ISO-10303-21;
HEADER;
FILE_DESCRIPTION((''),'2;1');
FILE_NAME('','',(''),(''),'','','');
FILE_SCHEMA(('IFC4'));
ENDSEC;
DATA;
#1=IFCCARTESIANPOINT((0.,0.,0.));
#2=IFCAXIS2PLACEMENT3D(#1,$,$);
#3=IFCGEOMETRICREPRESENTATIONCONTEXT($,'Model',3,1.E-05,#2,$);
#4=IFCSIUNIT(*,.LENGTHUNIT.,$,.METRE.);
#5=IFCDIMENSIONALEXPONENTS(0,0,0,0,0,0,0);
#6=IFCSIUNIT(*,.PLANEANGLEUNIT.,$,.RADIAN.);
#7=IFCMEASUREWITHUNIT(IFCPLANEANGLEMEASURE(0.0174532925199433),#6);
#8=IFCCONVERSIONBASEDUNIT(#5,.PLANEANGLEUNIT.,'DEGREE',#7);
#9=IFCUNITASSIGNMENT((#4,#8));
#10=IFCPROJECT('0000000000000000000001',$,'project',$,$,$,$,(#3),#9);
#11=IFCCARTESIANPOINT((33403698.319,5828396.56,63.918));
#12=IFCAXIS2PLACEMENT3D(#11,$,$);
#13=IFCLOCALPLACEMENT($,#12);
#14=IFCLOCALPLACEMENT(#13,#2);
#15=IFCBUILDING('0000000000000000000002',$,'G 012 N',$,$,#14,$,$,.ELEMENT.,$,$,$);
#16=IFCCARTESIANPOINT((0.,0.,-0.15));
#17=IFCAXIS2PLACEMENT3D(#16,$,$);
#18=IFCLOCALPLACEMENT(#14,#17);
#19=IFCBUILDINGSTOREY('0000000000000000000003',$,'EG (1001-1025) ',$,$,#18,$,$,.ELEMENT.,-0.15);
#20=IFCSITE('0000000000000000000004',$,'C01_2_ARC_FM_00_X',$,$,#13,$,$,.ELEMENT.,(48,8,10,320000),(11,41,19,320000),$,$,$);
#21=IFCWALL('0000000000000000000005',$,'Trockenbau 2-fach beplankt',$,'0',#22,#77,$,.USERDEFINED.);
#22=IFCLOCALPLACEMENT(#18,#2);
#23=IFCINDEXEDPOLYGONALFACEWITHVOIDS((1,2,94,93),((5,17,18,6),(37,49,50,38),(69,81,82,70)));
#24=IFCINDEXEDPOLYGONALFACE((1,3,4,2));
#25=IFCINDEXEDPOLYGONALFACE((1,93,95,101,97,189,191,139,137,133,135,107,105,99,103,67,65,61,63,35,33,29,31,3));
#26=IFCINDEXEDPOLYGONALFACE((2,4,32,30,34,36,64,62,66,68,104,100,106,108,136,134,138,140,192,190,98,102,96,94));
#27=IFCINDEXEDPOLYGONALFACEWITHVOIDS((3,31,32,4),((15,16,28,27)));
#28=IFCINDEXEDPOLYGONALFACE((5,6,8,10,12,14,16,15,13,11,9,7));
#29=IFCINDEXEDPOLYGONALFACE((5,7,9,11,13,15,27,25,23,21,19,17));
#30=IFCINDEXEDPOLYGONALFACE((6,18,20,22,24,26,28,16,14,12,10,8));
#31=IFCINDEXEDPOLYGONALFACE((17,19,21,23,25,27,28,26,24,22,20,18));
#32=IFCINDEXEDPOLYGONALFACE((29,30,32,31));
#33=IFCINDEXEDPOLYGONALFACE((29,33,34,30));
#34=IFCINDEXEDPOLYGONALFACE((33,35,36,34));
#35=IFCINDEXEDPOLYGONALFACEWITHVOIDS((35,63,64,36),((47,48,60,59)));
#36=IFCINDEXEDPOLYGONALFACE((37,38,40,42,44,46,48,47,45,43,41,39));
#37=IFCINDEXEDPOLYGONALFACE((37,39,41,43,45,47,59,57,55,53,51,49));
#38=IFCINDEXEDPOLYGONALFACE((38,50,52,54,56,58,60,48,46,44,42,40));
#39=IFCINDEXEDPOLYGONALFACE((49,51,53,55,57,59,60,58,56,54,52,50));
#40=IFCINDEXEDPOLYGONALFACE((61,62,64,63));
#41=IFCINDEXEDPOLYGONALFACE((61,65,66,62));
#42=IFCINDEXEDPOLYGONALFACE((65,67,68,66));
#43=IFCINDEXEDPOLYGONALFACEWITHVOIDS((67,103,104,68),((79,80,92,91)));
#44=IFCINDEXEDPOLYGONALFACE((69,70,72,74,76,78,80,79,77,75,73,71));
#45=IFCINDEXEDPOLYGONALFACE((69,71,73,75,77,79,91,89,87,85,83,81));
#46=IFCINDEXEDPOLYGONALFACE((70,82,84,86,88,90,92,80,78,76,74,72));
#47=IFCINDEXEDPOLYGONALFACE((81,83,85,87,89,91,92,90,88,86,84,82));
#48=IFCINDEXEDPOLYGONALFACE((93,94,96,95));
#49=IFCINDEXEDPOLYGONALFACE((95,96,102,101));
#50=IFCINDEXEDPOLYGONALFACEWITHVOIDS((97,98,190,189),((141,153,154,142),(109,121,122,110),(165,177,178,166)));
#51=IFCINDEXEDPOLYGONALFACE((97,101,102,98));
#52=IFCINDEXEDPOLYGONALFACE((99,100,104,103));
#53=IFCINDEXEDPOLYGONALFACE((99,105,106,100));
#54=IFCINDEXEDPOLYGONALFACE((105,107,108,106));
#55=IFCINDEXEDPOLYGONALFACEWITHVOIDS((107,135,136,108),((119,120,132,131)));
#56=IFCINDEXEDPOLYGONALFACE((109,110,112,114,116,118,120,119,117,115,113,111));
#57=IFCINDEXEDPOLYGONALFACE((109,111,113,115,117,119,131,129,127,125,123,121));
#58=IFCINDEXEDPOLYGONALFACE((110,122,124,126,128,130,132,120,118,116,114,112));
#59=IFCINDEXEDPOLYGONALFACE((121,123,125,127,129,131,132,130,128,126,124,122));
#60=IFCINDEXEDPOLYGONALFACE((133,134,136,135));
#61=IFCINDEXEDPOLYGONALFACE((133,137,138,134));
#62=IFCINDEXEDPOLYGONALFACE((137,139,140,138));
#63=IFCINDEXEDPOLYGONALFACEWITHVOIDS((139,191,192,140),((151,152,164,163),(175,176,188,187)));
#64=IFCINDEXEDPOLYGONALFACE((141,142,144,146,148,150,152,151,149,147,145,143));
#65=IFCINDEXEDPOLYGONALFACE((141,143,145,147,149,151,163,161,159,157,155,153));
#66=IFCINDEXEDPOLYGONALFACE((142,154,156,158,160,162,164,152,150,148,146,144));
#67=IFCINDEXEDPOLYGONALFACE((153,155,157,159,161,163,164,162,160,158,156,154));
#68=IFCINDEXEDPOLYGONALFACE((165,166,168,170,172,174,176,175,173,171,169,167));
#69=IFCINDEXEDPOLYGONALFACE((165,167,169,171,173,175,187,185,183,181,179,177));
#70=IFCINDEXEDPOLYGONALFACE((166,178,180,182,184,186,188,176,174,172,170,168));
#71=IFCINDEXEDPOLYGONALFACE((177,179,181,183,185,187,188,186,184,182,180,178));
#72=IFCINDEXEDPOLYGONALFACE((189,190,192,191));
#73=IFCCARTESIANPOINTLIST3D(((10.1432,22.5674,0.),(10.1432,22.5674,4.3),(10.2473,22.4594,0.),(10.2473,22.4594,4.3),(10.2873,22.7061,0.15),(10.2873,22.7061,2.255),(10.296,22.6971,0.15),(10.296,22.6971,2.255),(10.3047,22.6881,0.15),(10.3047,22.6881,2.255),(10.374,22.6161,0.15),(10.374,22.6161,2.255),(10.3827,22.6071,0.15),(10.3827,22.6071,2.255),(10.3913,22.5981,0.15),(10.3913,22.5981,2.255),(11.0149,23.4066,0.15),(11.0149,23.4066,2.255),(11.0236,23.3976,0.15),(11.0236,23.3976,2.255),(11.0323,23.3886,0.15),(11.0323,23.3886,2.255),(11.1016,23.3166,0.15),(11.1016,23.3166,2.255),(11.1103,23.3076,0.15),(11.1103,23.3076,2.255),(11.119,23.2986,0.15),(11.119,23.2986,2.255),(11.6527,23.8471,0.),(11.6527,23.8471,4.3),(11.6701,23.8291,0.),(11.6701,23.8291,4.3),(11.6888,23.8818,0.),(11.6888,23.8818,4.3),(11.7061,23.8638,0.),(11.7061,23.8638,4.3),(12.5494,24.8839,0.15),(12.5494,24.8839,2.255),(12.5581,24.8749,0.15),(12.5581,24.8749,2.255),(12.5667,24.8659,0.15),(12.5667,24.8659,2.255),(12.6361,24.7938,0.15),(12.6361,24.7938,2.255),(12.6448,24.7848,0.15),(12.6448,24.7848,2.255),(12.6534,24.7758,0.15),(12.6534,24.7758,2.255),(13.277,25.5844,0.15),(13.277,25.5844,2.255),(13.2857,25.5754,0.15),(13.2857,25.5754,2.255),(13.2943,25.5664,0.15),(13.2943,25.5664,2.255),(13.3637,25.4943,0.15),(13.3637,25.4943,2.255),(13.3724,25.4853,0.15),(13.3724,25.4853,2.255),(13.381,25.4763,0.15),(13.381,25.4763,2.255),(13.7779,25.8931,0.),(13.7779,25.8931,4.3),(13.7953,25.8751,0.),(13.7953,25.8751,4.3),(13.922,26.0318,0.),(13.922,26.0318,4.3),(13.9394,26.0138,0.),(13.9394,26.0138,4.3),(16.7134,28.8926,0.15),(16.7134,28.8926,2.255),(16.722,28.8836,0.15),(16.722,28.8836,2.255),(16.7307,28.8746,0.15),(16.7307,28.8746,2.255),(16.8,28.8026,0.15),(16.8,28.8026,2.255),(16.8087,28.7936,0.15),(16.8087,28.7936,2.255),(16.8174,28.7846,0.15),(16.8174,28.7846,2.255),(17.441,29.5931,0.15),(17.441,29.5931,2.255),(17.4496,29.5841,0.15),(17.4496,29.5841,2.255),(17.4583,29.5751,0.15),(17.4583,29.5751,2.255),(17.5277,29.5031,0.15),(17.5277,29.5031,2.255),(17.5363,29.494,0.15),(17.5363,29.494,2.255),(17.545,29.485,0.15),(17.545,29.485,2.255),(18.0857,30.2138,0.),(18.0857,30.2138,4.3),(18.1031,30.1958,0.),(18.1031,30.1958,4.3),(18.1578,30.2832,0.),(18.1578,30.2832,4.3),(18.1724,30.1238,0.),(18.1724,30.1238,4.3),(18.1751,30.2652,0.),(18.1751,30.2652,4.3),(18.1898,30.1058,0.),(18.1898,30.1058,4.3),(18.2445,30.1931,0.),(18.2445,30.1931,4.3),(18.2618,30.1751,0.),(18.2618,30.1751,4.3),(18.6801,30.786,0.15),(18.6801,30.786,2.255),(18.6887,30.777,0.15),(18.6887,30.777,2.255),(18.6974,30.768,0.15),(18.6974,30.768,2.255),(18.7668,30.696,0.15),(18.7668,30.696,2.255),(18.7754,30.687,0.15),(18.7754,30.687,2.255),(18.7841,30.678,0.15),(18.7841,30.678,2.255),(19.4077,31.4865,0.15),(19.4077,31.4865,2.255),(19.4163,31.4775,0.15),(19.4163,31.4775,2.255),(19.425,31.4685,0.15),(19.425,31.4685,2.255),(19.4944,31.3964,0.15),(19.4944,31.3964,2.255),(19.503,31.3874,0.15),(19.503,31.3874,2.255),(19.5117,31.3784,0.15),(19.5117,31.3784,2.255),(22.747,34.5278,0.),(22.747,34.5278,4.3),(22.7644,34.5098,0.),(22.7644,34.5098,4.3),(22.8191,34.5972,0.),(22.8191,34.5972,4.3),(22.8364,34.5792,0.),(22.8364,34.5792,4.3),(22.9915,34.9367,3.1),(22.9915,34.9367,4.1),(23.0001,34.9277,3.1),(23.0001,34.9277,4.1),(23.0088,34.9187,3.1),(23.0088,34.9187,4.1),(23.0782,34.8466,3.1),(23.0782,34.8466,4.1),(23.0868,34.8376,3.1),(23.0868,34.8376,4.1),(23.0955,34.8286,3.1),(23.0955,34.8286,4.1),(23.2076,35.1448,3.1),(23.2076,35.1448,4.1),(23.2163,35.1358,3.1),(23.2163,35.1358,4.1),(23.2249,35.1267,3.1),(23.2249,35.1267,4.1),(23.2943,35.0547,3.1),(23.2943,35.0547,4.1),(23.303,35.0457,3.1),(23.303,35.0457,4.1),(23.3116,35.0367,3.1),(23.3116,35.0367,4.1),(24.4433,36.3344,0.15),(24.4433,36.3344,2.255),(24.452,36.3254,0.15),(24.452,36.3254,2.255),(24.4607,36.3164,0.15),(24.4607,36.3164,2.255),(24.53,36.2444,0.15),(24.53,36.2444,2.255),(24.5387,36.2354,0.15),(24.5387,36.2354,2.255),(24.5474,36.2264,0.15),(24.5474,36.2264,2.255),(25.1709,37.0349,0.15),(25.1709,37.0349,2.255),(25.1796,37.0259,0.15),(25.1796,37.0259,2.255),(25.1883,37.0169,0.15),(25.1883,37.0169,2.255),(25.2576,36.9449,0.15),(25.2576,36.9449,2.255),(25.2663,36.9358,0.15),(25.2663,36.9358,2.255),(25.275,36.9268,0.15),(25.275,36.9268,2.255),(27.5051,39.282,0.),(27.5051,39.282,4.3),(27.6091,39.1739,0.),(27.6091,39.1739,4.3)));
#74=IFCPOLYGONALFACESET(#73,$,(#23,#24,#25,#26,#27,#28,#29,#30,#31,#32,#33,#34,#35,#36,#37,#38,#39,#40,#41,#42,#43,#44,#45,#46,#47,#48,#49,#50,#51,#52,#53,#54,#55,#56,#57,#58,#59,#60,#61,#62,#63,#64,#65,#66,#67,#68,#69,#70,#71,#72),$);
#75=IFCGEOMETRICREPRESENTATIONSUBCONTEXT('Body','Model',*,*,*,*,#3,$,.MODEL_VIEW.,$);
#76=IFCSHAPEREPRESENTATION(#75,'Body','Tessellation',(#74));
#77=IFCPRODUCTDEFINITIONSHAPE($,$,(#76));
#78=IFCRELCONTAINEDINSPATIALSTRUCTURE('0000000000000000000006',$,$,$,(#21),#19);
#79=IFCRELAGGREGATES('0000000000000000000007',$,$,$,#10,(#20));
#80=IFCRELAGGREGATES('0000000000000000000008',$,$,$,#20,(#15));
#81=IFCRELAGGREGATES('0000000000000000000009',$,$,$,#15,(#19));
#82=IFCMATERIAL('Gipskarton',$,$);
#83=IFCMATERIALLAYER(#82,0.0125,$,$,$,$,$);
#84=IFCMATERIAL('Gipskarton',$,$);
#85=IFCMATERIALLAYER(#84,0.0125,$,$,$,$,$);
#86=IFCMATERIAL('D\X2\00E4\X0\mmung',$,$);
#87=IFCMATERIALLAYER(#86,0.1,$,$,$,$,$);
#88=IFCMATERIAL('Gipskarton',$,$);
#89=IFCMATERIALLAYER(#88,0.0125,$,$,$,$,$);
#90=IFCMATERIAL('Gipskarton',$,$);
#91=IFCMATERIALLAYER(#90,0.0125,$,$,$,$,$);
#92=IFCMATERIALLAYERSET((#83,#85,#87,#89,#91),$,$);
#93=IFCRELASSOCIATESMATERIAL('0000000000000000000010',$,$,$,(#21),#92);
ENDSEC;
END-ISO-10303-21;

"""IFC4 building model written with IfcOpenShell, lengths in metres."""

from ifc_helpers import new_model, entity, si_unit, converted_unit, frame, origin, origin_with_axes, place, context, subcontext, project, spatial, polyline, outline, extrude, material, layer, layer_set, layer_usage, element, save


model = new_model("IFC4")

# Units and contexts
model_context = context("Model", 3, precision=1e-05, world=origin())
body_context = subcontext(model_context, "Body", "Model", "MODEL_VIEW")
ifc_project = project(units=[si_unit("LENGTHUNIT", "METRE"), converted_unit("PLANEANGLEUNIT", "DEGREE", entity("IfcPlaneAngleMeasure", 0.0174532925199433), si_unit("PLANEANGLEUNIT", "RADIAN"), dimensions=[0, 0, 0, 0, 0, 0, 0])], contexts=[model_context])

# Site, building, storey
site_placement = place(None, frame((33403698.319, 5828396.56, 63.918)))
site = spatial("IfcSite", under=ifc_project, at=site_placement, Name="C01_2_ARC_FM_00_X", CompositionType="ELEMENT", RefLatitude=(48, 8, 10, 320000), RefLongitude=(11, 41, 19, 320000))
building_placement = place(site_placement, origin())
building = spatial("IfcBuilding", under=site, at=building_placement, Name="G 012 N", CompositionType="ELEMENT")
storey_placement = place(building_placement, frame((0.0, 0.0, -0.15)))
storey = spatial("IfcBuildingStorey", under=building, at=storey_placement, Name="EG (1001-1025) ", CompositionType="ELEMENT", Elevation=-0.15)

# Wall, openings
ifc_material_1 = material(Name="Gipskarton")
ifc_layer_1 = layer(ifc_material_1, 0.0125)
ifc_material_2 = material(Name="Gipskarton")
ifc_layer_2 = layer(ifc_material_2, 0.0125)
ifc_material_3 = material(Name="Dämmung")
ifc_layer_3 = layer(ifc_material_3, 0.1)
ifc_material_4 = material(Name="Gipskarton")
ifc_layer_4 = layer(ifc_material_4, 0.0125)
ifc_material_5 = material(Name="Gipskarton")
ifc_layer_5 = layer(ifc_material_5, 0.0125)
ifc_layer_set_1 = layer_set([ifc_layer_1, ifc_layer_2, ifc_layer_3, ifc_layer_4, ifc_layer_5])
ifc_layer_usage_1 = layer_usage(ifc_layer_set_1, "AXIS2", "POSITIVE", 0.0)
wall_1_placement = place(storey_placement, frame((27.5051, 39.282, 0.0), z_axis=(0.0, 0.0, 1.0), x_axis=(-0.720408, -0.693551, 0.0)))
wall_1 = element("IfcWall", 1, at=wall_1_placement, inside=storey, material=ifc_layer_usage_1, Name="Trockenbau 2-fach beplankt", ObjectType="0", PredefinedType="USERDEFINED", context=body_context, shape_type="SweptSolid", body=[
    extrude(outline(polyline([(-11.1999, -0.0778), (-11.1999, -0.0528), (-11.0999, -0.0528), (-11.0999, -0.0778), (-0.0749, -0.0778), (-0.0749, 0.0722), (-2.0499, 0.0722), (-2.0499, 0.0472), (-2.0999, 0.0472), (-2.0999, 0.0722), (-4.9999, 0.0722), (-4.9999, 0.0472), (-5.1999, 0.0472), (-5.1999, 0.0722), (-11.0999, 0.0722), (-11.0999, 0.0472), (-11.1999, 0.0472), (-11.1999, 0.0722), (-17.4499, 0.0722), (-17.4499, 0.0472), (-17.5499, 0.0472), (-17.5499, 0.0722), (-24.1749, 0.0722), (-24.1749, -0.0778), (-11.1999, -0.0778)])), frame((24.1749, 0.0778, 0.0), z_axis=(0.0, 0.0, 1.0), x_axis=(1.0, 0.0, 0.0)), (0.0, 0.0, 1.0), 4.3),
])
opening_1_placement = place(wall_1_placement, frame((20.76, 0.0125, 0.15), z_axis=(0.0, -1.0, 0.0), x_axis=(0.0, 0.0, 1.0)))
element("IfcOpeningElement", 2, at=opening_1_placement, cuts=wall_1, ObjectType="0", PredefinedType="USERDEFINED", context=body_context, shape_type="SweptSolid", body=[
    extrude(outline(polyline([(0.0, 1.01), (2.105, 1.01), (2.105, 0.0), (0.0, 0.0), (0.0, 1.01)])), origin_with_axes(), (0.0, 0.0, 1.0), 0.0125),
    extrude(outline(polyline([(0.0, 1.01), (2.105, 1.01), (2.105, 0.0), (0.0, 0.0), (0.0, 1.01)])), frame((0.0, 0.0, -0.0125), z_axis=(0.0, 0.0, 1.0), x_axis=(1.0, 0.0, 0.0)), (0.0, 0.0, 1.0), 0.0125),
    extrude(outline(polyline([(0.0, 1.01), (2.105, 1.01), (2.105, 0.0), (0.0, 0.0), (0.0, 1.01)])), frame((0.0, 0.0, -0.1125), z_axis=(0.0, 0.0, 1.0), x_axis=(1.0, 0.0, 0.0)), (0.0, 0.0, 1.0), 0.1),
    extrude(outline(polyline([(0.0, 1.01), (2.105, 1.01), (2.105, 0.0), (0.0, 0.0), (0.0, 1.01)])), frame((0.0, 0.0, -0.125), z_axis=(0.0, 0.0, 1.0), x_axis=(1.0, 0.0, 0.0)), (0.0, 0.0, 1.0), 0.0125),
    extrude(outline(polyline([(0.0, 1.01), (2.105, 1.01), (2.105, 0.0), (0.0, 0.0), (0.0, 1.01)])), frame((0.0, 0.0, -0.1375), z_axis=(0.0, 0.0, 1.0), x_axis=(1.0, 0.0, 0.0)), (0.0, 0.0, 1.0), 0.0125),
])
opening_2_placement = place(wall_1_placement, frame((12.25, 0.0125, 0.15), z_axis=(0.0, -1.0, 0.0), x_axis=(0.0, 0.0, 1.0)))
element("IfcOpeningElement", 3, at=opening_2_placement, cuts=wall_1, ObjectType="0", PredefinedType="USERDEFINED", context=body_context, shape_type="SweptSolid", body=[
    extrude(outline(polyline([(0.0, 1.01), (2.105, 1.01), (2.105, 0.0), (0.0, 0.0), (0.0, 1.01)])), origin_with_axes(), (0.0, 0.0, 1.0), 0.0125),
    extrude(outline(polyline([(0.0, 1.01), (2.105, 1.01), (2.105, 0.0), (0.0, 0.0), (0.0, 1.01)])), frame((0.0, 0.0, -0.0125), z_axis=(0.0, 0.0, 1.0), x_axis=(1.0, 0.0, 0.0)), (0.0, 0.0, 1.0), 0.0125),
    extrude(outline(polyline([(0.0, 1.01), (2.105, 1.01), (2.105, 0.0), (0.0, 0.0), (0.0, 1.01)])), frame((0.0, 0.0, -0.1125), z_axis=(0.0, 0.0, 1.0), x_axis=(1.0, 0.0, 0.0)), (0.0, 0.0, 1.0), 0.1),
    extrude(outline(polyline([(0.0, 1.01), (2.105, 1.01), (2.105, 0.0), (0.0, 0.0), (0.0, 1.01)])), frame((0.0, 0.0, -0.125), z_axis=(0.0, 0.0, 1.0), x_axis=(1.0, 0.0, 0.0)), (0.0, 0.0, 1.0), 0.0125),
    extrude(outline(polyline([(0.0, 1.01), (2.105, 1.01), (2.105, 0.0), (0.0, 0.0), (0.0, 1.01)])), frame((0.0, 0.0, -0.1375), z_axis=(0.0, 0.0, 1.0), x_axis=(1.0, 0.0, 0.0)), (0.0, 0.0, 1.0), 0.0125),
])
opening_3_placement = place(wall_1_placement, frame((4.25, 0.0125, 0.15), z_axis=(0.0, -1.0, 0.0), x_axis=(0.0, 0.0, 1.0)))
element("IfcOpeningElement", 4, at=opening_3_placement, cuts=wall_1, ObjectType="0", PredefinedType="USERDEFINED", context=body_context, shape_type="SweptSolid", body=[
    extrude(outline(polyline([(0.0, 1.01), (2.105, 1.01), (2.105, 0.0), (0.0, 0.0), (0.0, 1.01)])), origin_with_axes(), (0.0, 0.0, 1.0), 0.0125),
    extrude(outline(polyline([(0.0, 1.01), (2.105, 1.01), (2.105, 0.0), (0.0, 0.0), (0.0, 1.01)])), frame((0.0, 0.0, -0.0125), z_axis=(0.0, 0.0, 1.0), x_axis=(1.0, 0.0, 0.0)), (0.0, 0.0, 1.0), 0.0125),
    extrude(outline(polyline([(0.0, 1.01), (2.105, 1.01), (2.105, 0.0), (0.0, 0.0), (0.0, 1.01)])), frame((0.0, 0.0, -0.1125), z_axis=(0.0, 0.0, 1.0), x_axis=(1.0, 0.0, 0.0)), (0.0, 0.0, 1.0), 0.1),
    extrude(outline(polyline([(0.0, 1.01), (2.105, 1.01), (2.105, 0.0), (0.0, 0.0), (0.0, 1.01)])), frame((0.0, 0.0, -0.125), z_axis=(0.0, 0.0, 1.0), x_axis=(1.0, 0.0, 0.0)), (0.0, 0.0, 1.0), 0.0125),
    extrude(outline(polyline([(0.0, 1.01), (2.105, 1.01), (2.105, 0.0), (0.0, 0.0), (0.0, 1.01)])), frame((0.0, 0.0, -0.1375), z_axis=(0.0, 0.0, 1.0), x_axis=(1.0, 0.0, 0.0)), (0.0, 0.0, 1.0), 0.0125),
])
opening_4_placement = place(wall_1_placement, frame((13.97, 0.0, 0.15), z_axis=(0.0, 1.0, 0.0), x_axis=(0.0, 0.0, 1.0)))
element("IfcOpeningElement", 5, at=opening_4_placement, cuts=wall_1, ObjectType="0", PredefinedType="USERDEFINED", context=body_context, shape_type="SweptSolid", body=[
    extrude(outline(polyline([(0.0, 1.01), (2.105, 1.01), (2.105, 0.0), (0.0, 0.0), (0.0, 1.01)])), origin_with_axes(), (0.0, 0.0, 1.0), 0.0125),
    extrude(outline(polyline([(0.0, 1.01), (2.105, 1.01), (2.105, 0.0), (0.0, 0.0), (0.0, 1.01)])), frame((0.0, 0.0, 0.0125), z_axis=(0.0, 0.0, 1.0), x_axis=(1.0, 0.0, 0.0)), (0.0, 0.0, 1.0), 0.0125),
    extrude(outline(polyline([(0.0, 1.01), (2.105, 1.01), (2.105, 0.0), (0.0, 0.0), (0.0, 1.01)])), frame((0.0, 0.0, 0.025), z_axis=(0.0, 0.0, 1.0), x_axis=(1.0, 0.0, 0.0)), (0.0, 0.0, 1.0), 0.1),
    extrude(outline(polyline([(0.0, 1.01), (2.105, 1.01), (2.105, 0.0), (0.0, 0.0), (0.0, 1.01)])), frame((0.0, 0.0, 0.125), z_axis=(0.0, 0.0, 1.0), x_axis=(1.0, 0.0, 0.0)), (0.0, 0.0, 1.0), 0.0125),
    extrude(outline(polyline([(0.0, 1.01), (2.105, 1.01), (2.105, 0.0), (0.0, 0.0), (0.0, 1.01)])), frame((0.0, 0.0, 0.1375), z_axis=(0.0, 0.0, 1.0), x_axis=(1.0, 0.0, 0.0)), (0.0, 0.0, 1.0), 0.0125),
])
opening_5_placement = place(wall_1_placement, frame((22.89, 0.0, 0.15), z_axis=(0.0, 1.0, 0.0), x_axis=(0.0, 0.0, 1.0)))
element("IfcOpeningElement", 6, at=opening_5_placement, cuts=wall_1, ObjectType="0", PredefinedType="USERDEFINED", context=body_context, shape_type="SweptSolid", body=[
    extrude(outline(polyline([(0.0, 1.01), (2.105, 1.01), (2.105, 0.0), (0.0, 0.0), (0.0, 1.01)])), origin_with_axes(), (0.0, 0.0, 1.0), 0.0125),
    extrude(outline(polyline([(0.0, 1.01), (2.105, 1.01), (2.105, 0.0), (0.0, 0.0), (0.0, 1.01)])), frame((0.0, 0.0, 0.0125), z_axis=(0.0, 0.0, 1.0), x_axis=(1.0, 0.0, 0.0)), (0.0, 0.0, 1.0), 0.0125),
    extrude(outline(polyline([(0.0, 1.01), (2.105, 1.01), (2.105, 0.0), (0.0, 0.0), (0.0, 1.01)])), frame((0.0, 0.0, 0.025), z_axis=(0.0, 0.0, 1.0), x_axis=(1.0, 0.0, 0.0)), (0.0, 0.0, 1.0), 0.1),
    extrude(outline(polyline([(0.0, 1.01), (2.105, 1.01), (2.105, 0.0), (0.0, 0.0), (0.0, 1.01)])), frame((0.0, 0.0, 0.125), z_axis=(0.0, 0.0, 1.0), x_axis=(1.0, 0.0, 0.0)), (0.0, 0.0, 1.0), 0.0125),
    extrude(outline(polyline([(0.0, 1.01), (2.105, 1.01), (2.105, 0.0), (0.0, 0.0), (0.0, 1.01)])), frame((0.0, 0.0, 0.1375), z_axis=(0.0, 0.0, 1.0), x_axis=(1.0, 0.0, 0.0)), (0.0, 0.0, 1.0), 0.0125),
])
opening_6_placement = place(wall_1_placement, frame((5.9653, 0.0, 3.1), z_axis=(0.0, 1.0, 0.0), x_axis=(0.0, 0.0, 1.0)))
element("IfcOpeningElement", 7, at=opening_6_placement, cuts=wall_1, ObjectType="Opening", context=body_context, shape_type="SweptSolid", body=[
    extrude(outline(polyline([(0.0, 0.3), (1.0, 0.3), (1.0, 0.0), (0.0, 0.0), (0.0, 0.3)])), origin_with_axes(), (0.0, 0.0, 1.0), 0.0125),
    extrude(outline(polyline([(0.0, 0.3), (1.0, 0.3), (1.0, 0.0), (0.0, 0.0), (0.0, 0.3)])), frame((0.0, 0.0, 0.0125), z_axis=(0.0, 0.0, 1.0), x_axis=(1.0, 0.0, 0.0)), (0.0, 0.0, 1.0), 0.0125),
    extrude(outline(polyline([(0.0, 0.3), (1.0, 0.3), (1.0, 0.0), (0.0, 0.0), (0.0, 0.3)])), frame((0.0, 0.0, 0.025), z_axis=(0.0, 0.0, 1.0), x_axis=(1.0, 0.0, 0.0)), (0.0, 0.0, 1.0), 0.1),
    extrude(outline(polyline([(0.0, 0.3), (1.0, 0.3), (1.0, 0.0), (0.0, 0.0), (0.0, 0.3)])), frame((0.0, 0.0, 0.125), z_axis=(0.0, 0.0, 1.0), x_axis=(1.0, 0.0, 0.0)), (0.0, 0.0, 1.0), 0.0125),
    extrude(outline(polyline([(0.0, 0.3), (1.0, 0.3), (1.0, 0.0), (0.0, 0.0), (0.0, 0.3)])), frame((0.0, 0.0, 0.1375), z_axis=(0.0, 0.0, 1.0), x_axis=(1.0, 0.0, 0.0)), (0.0, 0.0, 1.0), 0.0125),
])

save(model, "model.ifc")
